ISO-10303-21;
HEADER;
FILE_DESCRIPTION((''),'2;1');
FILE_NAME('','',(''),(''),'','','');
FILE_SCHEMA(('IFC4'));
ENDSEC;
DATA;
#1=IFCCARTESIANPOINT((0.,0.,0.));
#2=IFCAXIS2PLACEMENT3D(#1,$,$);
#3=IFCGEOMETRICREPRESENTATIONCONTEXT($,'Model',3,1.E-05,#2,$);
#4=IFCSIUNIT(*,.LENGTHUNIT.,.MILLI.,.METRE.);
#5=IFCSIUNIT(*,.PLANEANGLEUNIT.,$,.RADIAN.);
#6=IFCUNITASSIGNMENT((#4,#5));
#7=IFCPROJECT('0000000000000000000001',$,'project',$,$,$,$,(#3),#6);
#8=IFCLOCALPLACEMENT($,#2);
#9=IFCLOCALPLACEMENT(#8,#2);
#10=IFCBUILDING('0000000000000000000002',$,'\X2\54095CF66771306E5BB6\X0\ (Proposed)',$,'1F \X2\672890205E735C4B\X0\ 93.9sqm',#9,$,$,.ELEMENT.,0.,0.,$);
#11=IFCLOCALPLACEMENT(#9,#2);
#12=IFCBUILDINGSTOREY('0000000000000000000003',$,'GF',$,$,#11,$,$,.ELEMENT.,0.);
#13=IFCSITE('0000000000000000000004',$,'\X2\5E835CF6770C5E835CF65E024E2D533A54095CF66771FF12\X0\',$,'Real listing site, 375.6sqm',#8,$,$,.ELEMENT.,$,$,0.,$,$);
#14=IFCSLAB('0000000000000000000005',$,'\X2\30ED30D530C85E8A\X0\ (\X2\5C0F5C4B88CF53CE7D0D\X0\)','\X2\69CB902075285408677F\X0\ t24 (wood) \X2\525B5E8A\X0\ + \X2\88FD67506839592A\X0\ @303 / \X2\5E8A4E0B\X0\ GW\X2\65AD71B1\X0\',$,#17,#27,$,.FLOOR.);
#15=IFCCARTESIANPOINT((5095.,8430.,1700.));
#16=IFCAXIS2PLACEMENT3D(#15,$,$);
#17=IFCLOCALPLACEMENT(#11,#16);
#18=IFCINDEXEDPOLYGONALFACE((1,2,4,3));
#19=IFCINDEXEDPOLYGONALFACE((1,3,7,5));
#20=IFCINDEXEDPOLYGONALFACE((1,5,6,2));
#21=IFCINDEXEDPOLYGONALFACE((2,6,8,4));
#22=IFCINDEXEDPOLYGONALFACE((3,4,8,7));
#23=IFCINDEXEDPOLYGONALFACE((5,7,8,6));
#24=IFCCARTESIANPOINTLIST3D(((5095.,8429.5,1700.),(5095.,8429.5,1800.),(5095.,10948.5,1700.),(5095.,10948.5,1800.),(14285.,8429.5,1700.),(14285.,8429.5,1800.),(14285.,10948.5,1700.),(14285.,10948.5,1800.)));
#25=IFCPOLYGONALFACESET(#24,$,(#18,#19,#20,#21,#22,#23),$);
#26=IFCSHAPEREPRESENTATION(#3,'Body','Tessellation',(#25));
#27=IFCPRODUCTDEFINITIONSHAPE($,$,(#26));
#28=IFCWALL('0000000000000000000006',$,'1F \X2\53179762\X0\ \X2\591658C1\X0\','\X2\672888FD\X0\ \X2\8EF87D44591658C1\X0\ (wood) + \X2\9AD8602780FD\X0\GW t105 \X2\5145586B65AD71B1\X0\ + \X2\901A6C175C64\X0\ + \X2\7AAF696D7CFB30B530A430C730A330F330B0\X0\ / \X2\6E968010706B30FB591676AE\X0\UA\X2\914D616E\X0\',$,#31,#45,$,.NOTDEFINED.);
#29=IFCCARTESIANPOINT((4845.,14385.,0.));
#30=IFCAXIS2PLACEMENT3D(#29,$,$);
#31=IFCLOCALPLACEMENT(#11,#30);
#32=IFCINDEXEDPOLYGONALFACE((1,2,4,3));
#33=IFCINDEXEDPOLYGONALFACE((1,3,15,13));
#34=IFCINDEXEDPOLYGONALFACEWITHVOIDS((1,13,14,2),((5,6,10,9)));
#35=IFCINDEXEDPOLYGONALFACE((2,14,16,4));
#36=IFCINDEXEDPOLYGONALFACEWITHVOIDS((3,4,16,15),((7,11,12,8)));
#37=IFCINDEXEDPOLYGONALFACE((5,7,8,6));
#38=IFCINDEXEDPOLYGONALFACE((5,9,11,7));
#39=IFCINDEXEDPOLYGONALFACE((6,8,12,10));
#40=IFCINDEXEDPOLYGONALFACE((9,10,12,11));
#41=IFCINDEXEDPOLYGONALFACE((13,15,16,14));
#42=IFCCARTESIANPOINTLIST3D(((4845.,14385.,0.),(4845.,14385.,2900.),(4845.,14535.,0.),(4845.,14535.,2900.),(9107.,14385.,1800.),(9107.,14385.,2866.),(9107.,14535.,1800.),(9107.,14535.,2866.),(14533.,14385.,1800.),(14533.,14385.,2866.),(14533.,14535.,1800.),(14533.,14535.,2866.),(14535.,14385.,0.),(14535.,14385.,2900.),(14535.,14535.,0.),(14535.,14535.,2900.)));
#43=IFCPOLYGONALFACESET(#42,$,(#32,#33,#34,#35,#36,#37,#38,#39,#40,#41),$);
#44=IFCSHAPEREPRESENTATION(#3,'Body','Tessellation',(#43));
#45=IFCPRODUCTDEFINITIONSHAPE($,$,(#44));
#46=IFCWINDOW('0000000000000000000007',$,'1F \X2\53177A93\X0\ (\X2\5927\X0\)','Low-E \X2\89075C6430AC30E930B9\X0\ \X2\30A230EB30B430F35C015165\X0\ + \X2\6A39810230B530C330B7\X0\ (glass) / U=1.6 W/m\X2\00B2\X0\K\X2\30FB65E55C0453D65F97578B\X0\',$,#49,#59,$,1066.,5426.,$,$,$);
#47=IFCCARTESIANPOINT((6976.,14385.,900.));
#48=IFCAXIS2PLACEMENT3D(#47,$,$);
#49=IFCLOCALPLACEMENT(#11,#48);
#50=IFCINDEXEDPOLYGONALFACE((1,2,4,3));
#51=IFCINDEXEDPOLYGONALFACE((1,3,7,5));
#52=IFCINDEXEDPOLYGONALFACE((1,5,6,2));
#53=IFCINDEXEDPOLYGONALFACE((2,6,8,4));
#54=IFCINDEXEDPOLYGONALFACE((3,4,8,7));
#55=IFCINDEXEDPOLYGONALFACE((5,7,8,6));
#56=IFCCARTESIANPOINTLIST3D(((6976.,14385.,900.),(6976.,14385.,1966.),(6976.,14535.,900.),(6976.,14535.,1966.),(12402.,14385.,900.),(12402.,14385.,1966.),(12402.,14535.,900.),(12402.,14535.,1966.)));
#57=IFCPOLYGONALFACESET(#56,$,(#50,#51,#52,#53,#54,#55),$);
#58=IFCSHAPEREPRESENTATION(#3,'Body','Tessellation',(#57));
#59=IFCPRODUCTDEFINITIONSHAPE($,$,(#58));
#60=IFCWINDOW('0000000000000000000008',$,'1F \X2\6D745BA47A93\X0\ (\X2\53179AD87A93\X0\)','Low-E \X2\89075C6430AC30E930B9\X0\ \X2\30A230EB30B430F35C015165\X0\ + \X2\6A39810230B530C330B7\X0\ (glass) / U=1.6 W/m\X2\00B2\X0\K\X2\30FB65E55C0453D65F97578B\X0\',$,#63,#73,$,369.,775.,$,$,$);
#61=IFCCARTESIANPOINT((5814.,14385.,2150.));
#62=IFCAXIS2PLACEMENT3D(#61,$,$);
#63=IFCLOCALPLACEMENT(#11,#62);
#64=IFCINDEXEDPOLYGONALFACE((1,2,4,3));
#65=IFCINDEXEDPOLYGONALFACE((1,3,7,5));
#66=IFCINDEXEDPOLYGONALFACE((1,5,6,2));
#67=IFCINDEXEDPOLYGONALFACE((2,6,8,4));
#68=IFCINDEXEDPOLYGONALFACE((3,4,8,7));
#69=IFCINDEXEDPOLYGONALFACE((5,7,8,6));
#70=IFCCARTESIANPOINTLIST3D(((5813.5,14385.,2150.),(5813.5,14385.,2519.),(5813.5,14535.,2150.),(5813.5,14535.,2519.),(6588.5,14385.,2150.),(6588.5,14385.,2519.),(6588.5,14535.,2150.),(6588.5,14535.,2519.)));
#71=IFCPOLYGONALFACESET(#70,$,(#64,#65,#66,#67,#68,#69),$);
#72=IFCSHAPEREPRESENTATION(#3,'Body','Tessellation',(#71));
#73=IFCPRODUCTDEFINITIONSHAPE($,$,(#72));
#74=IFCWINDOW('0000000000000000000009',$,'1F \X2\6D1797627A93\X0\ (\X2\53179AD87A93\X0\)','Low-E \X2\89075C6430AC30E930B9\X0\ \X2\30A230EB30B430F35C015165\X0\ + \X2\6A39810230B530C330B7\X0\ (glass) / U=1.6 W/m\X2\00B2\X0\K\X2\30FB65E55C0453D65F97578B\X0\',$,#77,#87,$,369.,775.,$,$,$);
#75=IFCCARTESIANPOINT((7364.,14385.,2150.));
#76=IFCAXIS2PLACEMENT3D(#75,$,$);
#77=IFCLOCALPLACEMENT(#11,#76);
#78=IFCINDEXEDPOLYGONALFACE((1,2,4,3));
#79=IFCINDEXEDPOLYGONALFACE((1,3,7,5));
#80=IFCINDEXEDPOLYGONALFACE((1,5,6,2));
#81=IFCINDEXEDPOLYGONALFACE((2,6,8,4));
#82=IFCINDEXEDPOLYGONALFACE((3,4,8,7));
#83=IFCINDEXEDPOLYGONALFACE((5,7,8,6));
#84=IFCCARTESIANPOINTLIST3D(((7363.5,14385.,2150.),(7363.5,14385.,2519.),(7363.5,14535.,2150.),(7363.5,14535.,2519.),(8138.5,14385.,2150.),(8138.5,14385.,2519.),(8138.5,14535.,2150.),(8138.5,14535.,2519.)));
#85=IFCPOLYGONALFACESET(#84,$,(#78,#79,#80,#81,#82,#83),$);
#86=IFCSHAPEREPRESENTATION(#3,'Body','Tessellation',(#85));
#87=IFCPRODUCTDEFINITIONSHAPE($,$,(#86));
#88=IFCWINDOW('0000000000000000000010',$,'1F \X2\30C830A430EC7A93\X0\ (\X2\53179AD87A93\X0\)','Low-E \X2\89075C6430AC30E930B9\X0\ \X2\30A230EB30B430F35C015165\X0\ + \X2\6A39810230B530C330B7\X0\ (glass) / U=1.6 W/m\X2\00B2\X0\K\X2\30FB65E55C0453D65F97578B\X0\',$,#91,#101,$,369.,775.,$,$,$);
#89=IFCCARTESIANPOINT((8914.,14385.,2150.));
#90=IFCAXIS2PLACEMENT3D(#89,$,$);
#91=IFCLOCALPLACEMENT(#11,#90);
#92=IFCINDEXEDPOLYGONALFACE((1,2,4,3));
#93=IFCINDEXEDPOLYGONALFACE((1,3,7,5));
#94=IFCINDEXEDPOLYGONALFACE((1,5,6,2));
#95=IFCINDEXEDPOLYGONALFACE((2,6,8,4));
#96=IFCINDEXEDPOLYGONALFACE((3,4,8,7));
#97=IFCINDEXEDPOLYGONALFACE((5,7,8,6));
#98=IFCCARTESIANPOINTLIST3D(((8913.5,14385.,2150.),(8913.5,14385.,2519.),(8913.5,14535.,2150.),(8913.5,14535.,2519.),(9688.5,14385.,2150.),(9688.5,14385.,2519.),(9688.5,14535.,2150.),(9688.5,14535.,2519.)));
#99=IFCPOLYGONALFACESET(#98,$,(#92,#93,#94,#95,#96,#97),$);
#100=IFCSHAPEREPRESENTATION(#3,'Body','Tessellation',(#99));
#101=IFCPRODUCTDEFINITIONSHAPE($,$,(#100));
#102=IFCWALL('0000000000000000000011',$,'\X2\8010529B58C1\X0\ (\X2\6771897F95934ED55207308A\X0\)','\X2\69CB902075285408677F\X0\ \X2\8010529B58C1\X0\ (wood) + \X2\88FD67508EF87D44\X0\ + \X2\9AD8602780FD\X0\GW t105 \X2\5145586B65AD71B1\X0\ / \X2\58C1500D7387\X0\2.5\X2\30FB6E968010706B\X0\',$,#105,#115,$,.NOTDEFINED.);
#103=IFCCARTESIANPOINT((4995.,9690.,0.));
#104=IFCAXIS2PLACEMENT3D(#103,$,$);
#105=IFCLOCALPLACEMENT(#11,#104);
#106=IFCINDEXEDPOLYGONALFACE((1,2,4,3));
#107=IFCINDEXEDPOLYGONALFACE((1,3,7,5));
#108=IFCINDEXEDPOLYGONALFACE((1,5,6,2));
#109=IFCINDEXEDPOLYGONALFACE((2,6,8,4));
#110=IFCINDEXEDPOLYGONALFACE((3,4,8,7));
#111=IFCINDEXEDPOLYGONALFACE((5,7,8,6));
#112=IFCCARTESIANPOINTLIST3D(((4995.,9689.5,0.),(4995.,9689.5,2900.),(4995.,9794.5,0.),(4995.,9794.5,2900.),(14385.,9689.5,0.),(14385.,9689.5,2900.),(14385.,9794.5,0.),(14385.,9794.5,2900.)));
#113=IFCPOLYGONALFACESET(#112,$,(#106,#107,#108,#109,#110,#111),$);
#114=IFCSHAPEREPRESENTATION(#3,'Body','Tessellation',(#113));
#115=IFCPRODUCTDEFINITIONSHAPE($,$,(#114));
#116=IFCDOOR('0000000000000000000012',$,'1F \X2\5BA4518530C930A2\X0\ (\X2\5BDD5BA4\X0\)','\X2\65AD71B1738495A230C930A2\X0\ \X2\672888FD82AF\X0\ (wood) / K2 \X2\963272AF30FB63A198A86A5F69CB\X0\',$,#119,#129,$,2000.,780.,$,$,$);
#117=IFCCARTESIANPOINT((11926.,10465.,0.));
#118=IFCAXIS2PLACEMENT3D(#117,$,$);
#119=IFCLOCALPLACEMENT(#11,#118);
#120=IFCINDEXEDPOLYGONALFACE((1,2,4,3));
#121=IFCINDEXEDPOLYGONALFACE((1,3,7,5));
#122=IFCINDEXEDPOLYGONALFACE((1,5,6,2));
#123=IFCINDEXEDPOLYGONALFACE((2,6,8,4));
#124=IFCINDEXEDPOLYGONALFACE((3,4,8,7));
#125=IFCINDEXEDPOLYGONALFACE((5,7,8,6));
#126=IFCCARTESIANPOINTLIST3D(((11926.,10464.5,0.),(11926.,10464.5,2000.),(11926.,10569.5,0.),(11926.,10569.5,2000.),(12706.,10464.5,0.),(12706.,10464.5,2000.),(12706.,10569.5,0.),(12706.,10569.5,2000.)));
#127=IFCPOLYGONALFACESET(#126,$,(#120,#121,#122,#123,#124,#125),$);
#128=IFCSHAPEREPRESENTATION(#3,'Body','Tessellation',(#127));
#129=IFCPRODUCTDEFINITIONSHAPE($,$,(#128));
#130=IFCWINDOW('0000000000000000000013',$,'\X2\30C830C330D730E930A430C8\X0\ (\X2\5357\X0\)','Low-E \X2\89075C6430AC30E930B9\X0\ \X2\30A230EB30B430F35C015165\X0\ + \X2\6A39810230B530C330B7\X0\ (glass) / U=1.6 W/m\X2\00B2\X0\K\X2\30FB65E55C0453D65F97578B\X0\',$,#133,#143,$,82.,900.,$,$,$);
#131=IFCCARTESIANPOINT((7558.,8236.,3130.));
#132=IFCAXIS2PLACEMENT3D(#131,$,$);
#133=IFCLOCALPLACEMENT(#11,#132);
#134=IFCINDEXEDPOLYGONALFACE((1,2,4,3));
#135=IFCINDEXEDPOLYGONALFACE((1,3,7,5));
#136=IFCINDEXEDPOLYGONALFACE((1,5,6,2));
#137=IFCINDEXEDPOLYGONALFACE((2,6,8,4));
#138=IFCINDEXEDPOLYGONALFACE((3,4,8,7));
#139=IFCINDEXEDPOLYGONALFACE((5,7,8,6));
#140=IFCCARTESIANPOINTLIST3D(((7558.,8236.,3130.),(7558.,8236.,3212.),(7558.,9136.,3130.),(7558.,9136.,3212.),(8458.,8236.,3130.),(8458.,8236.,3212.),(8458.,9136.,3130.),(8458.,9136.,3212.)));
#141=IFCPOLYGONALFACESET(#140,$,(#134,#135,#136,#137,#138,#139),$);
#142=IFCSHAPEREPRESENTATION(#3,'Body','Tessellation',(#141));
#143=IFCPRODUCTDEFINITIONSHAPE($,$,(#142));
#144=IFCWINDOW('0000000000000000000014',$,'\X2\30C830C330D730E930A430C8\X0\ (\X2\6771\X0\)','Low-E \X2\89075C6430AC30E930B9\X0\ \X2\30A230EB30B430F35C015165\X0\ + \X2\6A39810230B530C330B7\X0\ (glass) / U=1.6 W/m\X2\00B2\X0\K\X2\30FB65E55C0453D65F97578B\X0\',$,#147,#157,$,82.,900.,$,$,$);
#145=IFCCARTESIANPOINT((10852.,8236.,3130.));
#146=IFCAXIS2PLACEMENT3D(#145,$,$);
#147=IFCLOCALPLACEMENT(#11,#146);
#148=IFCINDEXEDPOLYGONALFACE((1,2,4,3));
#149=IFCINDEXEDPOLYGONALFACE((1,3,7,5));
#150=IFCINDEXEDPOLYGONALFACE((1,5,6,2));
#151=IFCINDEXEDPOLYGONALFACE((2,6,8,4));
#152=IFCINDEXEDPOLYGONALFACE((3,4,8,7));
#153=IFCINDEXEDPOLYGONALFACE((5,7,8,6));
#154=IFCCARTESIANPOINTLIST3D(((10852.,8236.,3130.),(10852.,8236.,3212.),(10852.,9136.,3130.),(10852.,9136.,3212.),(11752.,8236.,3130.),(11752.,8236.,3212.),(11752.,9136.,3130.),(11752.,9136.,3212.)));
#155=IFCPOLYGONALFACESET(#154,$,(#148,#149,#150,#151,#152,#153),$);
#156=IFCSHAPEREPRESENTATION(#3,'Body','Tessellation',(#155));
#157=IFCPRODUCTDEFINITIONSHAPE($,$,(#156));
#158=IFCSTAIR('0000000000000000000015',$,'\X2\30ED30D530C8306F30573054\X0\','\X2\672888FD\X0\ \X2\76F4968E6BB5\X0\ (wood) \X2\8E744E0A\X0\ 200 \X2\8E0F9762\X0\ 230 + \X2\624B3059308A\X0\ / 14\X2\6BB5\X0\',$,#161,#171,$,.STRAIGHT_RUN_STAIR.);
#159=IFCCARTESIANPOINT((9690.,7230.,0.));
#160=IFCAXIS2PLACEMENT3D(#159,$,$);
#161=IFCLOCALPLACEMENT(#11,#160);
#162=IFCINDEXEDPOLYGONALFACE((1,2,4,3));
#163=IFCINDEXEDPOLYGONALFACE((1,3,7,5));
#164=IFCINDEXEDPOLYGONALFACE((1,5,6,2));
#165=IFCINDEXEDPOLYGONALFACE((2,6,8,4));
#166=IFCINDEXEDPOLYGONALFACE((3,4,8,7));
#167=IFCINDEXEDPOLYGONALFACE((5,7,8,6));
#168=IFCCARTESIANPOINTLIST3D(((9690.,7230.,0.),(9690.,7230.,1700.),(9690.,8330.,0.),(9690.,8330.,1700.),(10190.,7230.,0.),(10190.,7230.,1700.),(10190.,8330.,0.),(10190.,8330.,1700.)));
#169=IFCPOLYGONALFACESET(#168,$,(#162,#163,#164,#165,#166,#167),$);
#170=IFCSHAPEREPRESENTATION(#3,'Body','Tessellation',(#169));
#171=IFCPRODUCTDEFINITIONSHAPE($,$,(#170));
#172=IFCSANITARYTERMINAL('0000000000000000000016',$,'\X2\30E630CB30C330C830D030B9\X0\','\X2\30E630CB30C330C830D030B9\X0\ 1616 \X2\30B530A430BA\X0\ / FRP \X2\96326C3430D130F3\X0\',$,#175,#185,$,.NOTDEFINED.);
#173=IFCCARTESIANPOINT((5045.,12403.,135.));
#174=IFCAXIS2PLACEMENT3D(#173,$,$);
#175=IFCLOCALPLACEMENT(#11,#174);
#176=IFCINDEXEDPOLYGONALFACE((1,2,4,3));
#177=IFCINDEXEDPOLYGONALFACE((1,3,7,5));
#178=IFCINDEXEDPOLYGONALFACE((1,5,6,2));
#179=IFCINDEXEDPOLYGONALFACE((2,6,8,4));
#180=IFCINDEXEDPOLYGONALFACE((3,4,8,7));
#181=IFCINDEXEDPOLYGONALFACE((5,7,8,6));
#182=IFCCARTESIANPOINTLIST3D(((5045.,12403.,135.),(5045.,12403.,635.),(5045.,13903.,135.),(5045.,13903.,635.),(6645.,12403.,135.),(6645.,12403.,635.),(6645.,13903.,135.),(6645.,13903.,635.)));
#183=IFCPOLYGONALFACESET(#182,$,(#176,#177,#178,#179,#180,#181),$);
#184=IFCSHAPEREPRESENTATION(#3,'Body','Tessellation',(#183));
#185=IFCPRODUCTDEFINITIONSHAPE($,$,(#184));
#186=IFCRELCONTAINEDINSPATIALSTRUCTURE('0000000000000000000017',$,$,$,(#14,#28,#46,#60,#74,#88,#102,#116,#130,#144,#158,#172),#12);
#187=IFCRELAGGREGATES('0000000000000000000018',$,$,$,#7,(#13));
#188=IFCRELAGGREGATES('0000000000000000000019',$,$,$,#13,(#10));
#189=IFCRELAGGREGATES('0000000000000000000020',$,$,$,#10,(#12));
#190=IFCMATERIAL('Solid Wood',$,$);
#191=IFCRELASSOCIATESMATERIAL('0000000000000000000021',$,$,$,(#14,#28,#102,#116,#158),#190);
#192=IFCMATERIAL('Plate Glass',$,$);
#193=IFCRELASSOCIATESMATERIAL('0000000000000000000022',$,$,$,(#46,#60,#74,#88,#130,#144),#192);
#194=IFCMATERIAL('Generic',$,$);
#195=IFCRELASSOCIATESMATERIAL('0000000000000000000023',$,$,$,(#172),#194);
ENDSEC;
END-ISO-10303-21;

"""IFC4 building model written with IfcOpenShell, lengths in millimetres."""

from ifc_helpers import new_model, si_unit, frame, frame_2d, origin, place, context, project, spatial, rectangle, extrude, material, element, fill, save


model = new_model("IFC4")

# Units and contexts
model_context = context("Model", 3, precision=1e-05, world=origin())
ifc_project = project(units=[si_unit("LENGTHUNIT", "METRE", prefix="MILLI"), si_unit("PLANEANGLEUNIT", "RADIAN")], contexts=[model_context])

# Site, building, storey
site_placement = place(None, origin())
site = spatial("IfcSite", under=ifc_project, at=site_placement, Name="広島県広島市中区吉島東２", ObjectType="Real listing site, 375.6sqm", CompositionType="ELEMENT", RefElevation=0.0)
building_placement = place(site_placement, origin())
building = spatial("IfcBuilding", under=site, at=building_placement, Name="吉島東の家 (Proposed)", ObjectType="1F 木造平屋 93.9sqm", CompositionType="ELEMENT", ElevationOfRefHeight=0.0, ElevationOfTerrain=0.0)
storey_placement = place(building_placement, origin())
storey = spatial("IfcBuildingStorey", under=building, at=storey_placement, Name="GF", CompositionType="ELEMENT", Elevation=0.0)

# Slab
ifc_material_1 = material(Name="Solid Wood")
slab_placement = place(storey_placement, frame((5095.0, 8430.0, 1700.0)))
element("IfcSlab", 1, at=slab_placement, inside=storey, material=ifc_material_1, Name="ロフト床 (小屋裏収納)", Description="構造用合板 t24 (wood) 剛床 + 製材根太 @303 / 床下 GW断熱", PredefinedType="FLOOR", context=model_context, shape_type="SweptSolid", body=[
    extrude(rectangle(XDim=9190.0, YDim=2519.0, at=frame_2d((4595.0, 1259.0))), frame((5095.0, 8430.0, 1700.0)), (0.0, 0.0, 1.0), 100.0),
])

# Wall, openings, windows
wall_1_placement = place(storey_placement, frame((4845.0, 14385.0, 0.0)))
wall_1 = element("IfcWall", 2, at=wall_1_placement, inside=storey, material=ifc_material_1, Name="1F 北面 外壁", Description="木製 軸組外壁 (wood) + 高性能GW t105 充填断熱 + 通気層 + 窯業系サイディング / 準耐火・外皮UA配慮", PredefinedType="NOTDEFINED", context=model_context, shape_type="SweptSolid", body=[
    extrude(rectangle(XDim=9690.0, YDim=150.0, at=frame_2d((4845.0, 75.0))), frame((4845.0, 14385.0, 0.0)), (0.0, 0.0, 1.0), 2900.0),
])
opening_1_placement = place(storey_placement, frame((6976.0, 14385.0, 900.0)))
opening_1 = element("IfcOpeningElement", 3, at=opening_1_placement, cuts=wall_1, PredefinedType="NOTDEFINED", context=model_context, shape_type="SweptSolid", body=[
    extrude(rectangle(XDim=5426.0, YDim=150.0, at=frame_2d((2713.0, 75.0))), frame((6976.0, 14385.0, 900.0)), (0.0, 0.0, 1.0), 1066.0),
])
opening_2_placement = place(storey_placement, frame((5814.0, 14385.0, 2150.0)))
opening_2 = element("IfcOpeningElement", 4, at=opening_2_placement, cuts=wall_1, PredefinedType="NOTDEFINED", context=model_context, shape_type="SweptSolid", body=[
    extrude(rectangle(XDim=775.0, YDim=150.0, at=frame_2d((387.0, 75.0))), frame((5814.0, 14385.0, 2150.0)), (0.0, 0.0, 1.0), 369.0),
])
opening_3_placement = place(storey_placement, frame((7364.0, 14385.0, 2150.0)))
opening_3 = element("IfcOpeningElement", 5, at=opening_3_placement, cuts=wall_1, PredefinedType="NOTDEFINED", context=model_context, shape_type="SweptSolid", body=[
    extrude(rectangle(XDim=775.0, YDim=150.0, at=frame_2d((387.0, 75.0))), frame((7364.0, 14385.0, 2150.0)), (0.0, 0.0, 1.0), 369.0),
])
opening_4_placement = place(storey_placement, frame((8914.0, 14385.0, 2150.0)))
opening_4 = element("IfcOpeningElement", 6, at=opening_4_placement, cuts=wall_1, PredefinedType="NOTDEFINED", context=model_context, shape_type="SweptSolid", body=[
    extrude(rectangle(XDim=775.0, YDim=150.0, at=frame_2d((387.0, 75.0))), frame((8914.0, 14385.0, 2150.0)), (0.0, 0.0, 1.0), 369.0),
])
ifc_material_2 = material(Name="Plate Glass")
window_1_placement = place(storey_placement, frame((6976.0, 14385.0, 900.0)))
window_1 = element("IfcWindow", 7, at=window_1_placement, inside=storey, material=ifc_material_2, Name="1F 北窓 (大)", Description="Low-E 複層ガラス アルゴン封入 + 樹脂サッシ (glass) / U=1.6 W/m²K・日射取得型", OverallHeight=1066.0, OverallWidth=5426.0, context=model_context, shape_type="SweptSolid", body=[
    extrude(rectangle(XDim=5426.0, YDim=150.0, at=frame_2d((2713.0, 75.0))), frame((6976.0, 14385.0, 900.0)), (0.0, 0.0, 1.0), 1066.0),
])
fill(opening_1, window_1)
window_2_placement = place(storey_placement, frame((5814.0, 14385.0, 2150.0)))
window_2 = element("IfcWindow", 8, at=window_2_placement, inside=storey, material=ifc_material_2, Name="1F 浴室窓 (北高窓)", Description="Low-E 複層ガラス アルゴン封入 + 樹脂サッシ (glass) / U=1.6 W/m²K・日射取得型", OverallHeight=369.0, OverallWidth=775.0, context=model_context, shape_type="SweptSolid", body=[
    extrude(rectangle(XDim=775.0, YDim=150.0, at=frame_2d((387.0, 75.0))), frame((5814.0, 14385.0, 2150.0)), (0.0, 0.0, 1.0), 369.0),
])
fill(opening_2, window_2)
window_3_placement = place(storey_placement, frame((7364.0, 14385.0, 2150.0)))
window_3 = element("IfcWindow", 9, at=window_3_placement, inside=storey, material=ifc_material_2, Name="1F 洗面窓 (北高窓)", Description="Low-E 複層ガラス アルゴン封入 + 樹脂サッシ (glass) / U=1.6 W/m²K・日射取得型", OverallHeight=369.0, OverallWidth=775.0, context=model_context, shape_type="SweptSolid", body=[
    extrude(rectangle(XDim=775.0, YDim=150.0, at=frame_2d((387.0, 75.0))), frame((7364.0, 14385.0, 2150.0)), (0.0, 0.0, 1.0), 369.0),
])
fill(opening_3, window_3)
window_4_placement = place(storey_placement, frame((8914.0, 14385.0, 2150.0)))
window_4 = element("IfcWindow", 10, at=window_4_placement, inside=storey, material=ifc_material_2, Name="1F トイレ窓 (北高窓)", Description="Low-E 複層ガラス アルゴン封入 + 樹脂サッシ (glass) / U=1.6 W/m²K・日射取得型", OverallHeight=369.0, OverallWidth=775.0, context=model_context, shape_type="SweptSolid", body=[
    extrude(rectangle(XDim=775.0, YDim=150.0, at=frame_2d((387.0, 75.0))), frame((8914.0, 14385.0, 2150.0)), (0.0, 0.0, 1.0), 369.0),
])
fill(opening_4, window_4)

# Wall
wall_2_placement = place(storey_placement, frame((4995.0, 9690.0, 0.0)))
element("IfcWall", 11, at=wall_2_placement, inside=storey, material=ifc_material_1, Name="耐力壁 (東西間仕切り)", Description="構造用合板 耐力壁 (wood) + 製材軸組 + 高性能GW t105 充填断熱 / 壁倍率2.5・準耐火", PredefinedType="NOTDEFINED", context=model_context, shape_type="SweptSolid", body=[
    extrude(rectangle(XDim=9390.0, YDim=105.0, at=frame_2d((4695.0, 52.0))), frame((4995.0, 9690.0, 0.0)), (0.0, 0.0, 1.0), 2900.0),
])

# Door
door_1_placement = place(storey_placement, frame((11926.0, 10465.0, 0.0)))
element("IfcDoor", 12, at=door_1_placement, inside=storey, material=ifc_material_1, Name="1F 室内ドア (寝室)", Description="断熱玄関ドア 木製芯 (wood) / K2 防犯・採風機構", OverallHeight=2000.0, OverallWidth=780.0, context=model_context, shape_type="SweptSolid", body=[
    extrude(rectangle(XDim=780.0, YDim=105.0, at=frame_2d((390.0, 52.0))), frame((11926.0, 10465.0, 0.0)), (0.0, 0.0, 1.0), 2000.0),
])

# Windows
window_5_placement = place(storey_placement, frame((7558.0, 8236.0, 3130.0)))
element("IfcWindow", 13, at=window_5_placement, inside=storey, material=ifc_material_2, Name="トップライト (南)", Description="Low-E 複層ガラス アルゴン封入 + 樹脂サッシ (glass) / U=1.6 W/m²K・日射取得型", OverallHeight=82.0, OverallWidth=900.0, context=model_context, shape_type="SweptSolid", body=[
    extrude(rectangle(XDim=900.0, YDim=900.0, at=frame_2d((450.0, 450.0))), frame((7558.0, 8236.0, 3130.0)), (0.0, 0.0, 1.0), 82.0),
])
window_6_placement = place(storey_placement, frame((10852.0, 8236.0, 3130.0)))
element("IfcWindow", 14, at=window_6_placement, inside=storey, material=ifc_material_2, Name="トップライト (東)", Description="Low-E 複層ガラス アルゴン封入 + 樹脂サッシ (glass) / U=1.6 W/m²K・日射取得型", OverallHeight=82.0, OverallWidth=900.0, context=model_context, shape_type="SweptSolid", body=[
    extrude(rectangle(XDim=900.0, YDim=900.0, at=frame_2d((450.0, 450.0))), frame((10852.0, 8236.0, 3130.0)), (0.0, 0.0, 1.0), 82.0),
])

# Stair
stair_placement = place(storey_placement, frame((9690.0, 7230.0, 0.0)))
element("IfcStair", 15, at=stair_placement, inside=storey, material=ifc_material_1, Name="ロフトはしご", Description="木製 直階段 (wood) 蹴上 200 踏面 230 + 手すり / 14段", PredefinedType="STRAIGHT_RUN_STAIR", context=model_context, shape_type="SweptSolid", body=[
    extrude(rectangle(XDim=500.0, YDim=1100.0, at=frame_2d((250.0, 550.0))), frame((9690.0, 7230.0, 0.0)), (0.0, 0.0, 1.0), 1700.0),
])

# Sanitary terminal
ifc_material_3 = material(Name="Generic")
sanitary_terminal_1_placement = place(storey_placement, frame((5045.0, 12403.0, 135.0)))
element("IfcSanitaryTerminal", 16, at=sanitary_terminal_1_placement, inside=storey, material=ifc_material_3, Name="ユニットバス", Description="ユニットバス 1616 サイズ / FRP 防水パン", PredefinedType="NOTDEFINED", context=model_context, shape_type="SweptSolid", body=[
    extrude(rectangle(XDim=1600.0, YDim=1500.0, at=frame_2d((800.0, 750.0))), frame((5045.0, 12403.0, 135.0)), (0.0, 0.0, 1.0), 500.0),
])

save(model, "model.ifc")
